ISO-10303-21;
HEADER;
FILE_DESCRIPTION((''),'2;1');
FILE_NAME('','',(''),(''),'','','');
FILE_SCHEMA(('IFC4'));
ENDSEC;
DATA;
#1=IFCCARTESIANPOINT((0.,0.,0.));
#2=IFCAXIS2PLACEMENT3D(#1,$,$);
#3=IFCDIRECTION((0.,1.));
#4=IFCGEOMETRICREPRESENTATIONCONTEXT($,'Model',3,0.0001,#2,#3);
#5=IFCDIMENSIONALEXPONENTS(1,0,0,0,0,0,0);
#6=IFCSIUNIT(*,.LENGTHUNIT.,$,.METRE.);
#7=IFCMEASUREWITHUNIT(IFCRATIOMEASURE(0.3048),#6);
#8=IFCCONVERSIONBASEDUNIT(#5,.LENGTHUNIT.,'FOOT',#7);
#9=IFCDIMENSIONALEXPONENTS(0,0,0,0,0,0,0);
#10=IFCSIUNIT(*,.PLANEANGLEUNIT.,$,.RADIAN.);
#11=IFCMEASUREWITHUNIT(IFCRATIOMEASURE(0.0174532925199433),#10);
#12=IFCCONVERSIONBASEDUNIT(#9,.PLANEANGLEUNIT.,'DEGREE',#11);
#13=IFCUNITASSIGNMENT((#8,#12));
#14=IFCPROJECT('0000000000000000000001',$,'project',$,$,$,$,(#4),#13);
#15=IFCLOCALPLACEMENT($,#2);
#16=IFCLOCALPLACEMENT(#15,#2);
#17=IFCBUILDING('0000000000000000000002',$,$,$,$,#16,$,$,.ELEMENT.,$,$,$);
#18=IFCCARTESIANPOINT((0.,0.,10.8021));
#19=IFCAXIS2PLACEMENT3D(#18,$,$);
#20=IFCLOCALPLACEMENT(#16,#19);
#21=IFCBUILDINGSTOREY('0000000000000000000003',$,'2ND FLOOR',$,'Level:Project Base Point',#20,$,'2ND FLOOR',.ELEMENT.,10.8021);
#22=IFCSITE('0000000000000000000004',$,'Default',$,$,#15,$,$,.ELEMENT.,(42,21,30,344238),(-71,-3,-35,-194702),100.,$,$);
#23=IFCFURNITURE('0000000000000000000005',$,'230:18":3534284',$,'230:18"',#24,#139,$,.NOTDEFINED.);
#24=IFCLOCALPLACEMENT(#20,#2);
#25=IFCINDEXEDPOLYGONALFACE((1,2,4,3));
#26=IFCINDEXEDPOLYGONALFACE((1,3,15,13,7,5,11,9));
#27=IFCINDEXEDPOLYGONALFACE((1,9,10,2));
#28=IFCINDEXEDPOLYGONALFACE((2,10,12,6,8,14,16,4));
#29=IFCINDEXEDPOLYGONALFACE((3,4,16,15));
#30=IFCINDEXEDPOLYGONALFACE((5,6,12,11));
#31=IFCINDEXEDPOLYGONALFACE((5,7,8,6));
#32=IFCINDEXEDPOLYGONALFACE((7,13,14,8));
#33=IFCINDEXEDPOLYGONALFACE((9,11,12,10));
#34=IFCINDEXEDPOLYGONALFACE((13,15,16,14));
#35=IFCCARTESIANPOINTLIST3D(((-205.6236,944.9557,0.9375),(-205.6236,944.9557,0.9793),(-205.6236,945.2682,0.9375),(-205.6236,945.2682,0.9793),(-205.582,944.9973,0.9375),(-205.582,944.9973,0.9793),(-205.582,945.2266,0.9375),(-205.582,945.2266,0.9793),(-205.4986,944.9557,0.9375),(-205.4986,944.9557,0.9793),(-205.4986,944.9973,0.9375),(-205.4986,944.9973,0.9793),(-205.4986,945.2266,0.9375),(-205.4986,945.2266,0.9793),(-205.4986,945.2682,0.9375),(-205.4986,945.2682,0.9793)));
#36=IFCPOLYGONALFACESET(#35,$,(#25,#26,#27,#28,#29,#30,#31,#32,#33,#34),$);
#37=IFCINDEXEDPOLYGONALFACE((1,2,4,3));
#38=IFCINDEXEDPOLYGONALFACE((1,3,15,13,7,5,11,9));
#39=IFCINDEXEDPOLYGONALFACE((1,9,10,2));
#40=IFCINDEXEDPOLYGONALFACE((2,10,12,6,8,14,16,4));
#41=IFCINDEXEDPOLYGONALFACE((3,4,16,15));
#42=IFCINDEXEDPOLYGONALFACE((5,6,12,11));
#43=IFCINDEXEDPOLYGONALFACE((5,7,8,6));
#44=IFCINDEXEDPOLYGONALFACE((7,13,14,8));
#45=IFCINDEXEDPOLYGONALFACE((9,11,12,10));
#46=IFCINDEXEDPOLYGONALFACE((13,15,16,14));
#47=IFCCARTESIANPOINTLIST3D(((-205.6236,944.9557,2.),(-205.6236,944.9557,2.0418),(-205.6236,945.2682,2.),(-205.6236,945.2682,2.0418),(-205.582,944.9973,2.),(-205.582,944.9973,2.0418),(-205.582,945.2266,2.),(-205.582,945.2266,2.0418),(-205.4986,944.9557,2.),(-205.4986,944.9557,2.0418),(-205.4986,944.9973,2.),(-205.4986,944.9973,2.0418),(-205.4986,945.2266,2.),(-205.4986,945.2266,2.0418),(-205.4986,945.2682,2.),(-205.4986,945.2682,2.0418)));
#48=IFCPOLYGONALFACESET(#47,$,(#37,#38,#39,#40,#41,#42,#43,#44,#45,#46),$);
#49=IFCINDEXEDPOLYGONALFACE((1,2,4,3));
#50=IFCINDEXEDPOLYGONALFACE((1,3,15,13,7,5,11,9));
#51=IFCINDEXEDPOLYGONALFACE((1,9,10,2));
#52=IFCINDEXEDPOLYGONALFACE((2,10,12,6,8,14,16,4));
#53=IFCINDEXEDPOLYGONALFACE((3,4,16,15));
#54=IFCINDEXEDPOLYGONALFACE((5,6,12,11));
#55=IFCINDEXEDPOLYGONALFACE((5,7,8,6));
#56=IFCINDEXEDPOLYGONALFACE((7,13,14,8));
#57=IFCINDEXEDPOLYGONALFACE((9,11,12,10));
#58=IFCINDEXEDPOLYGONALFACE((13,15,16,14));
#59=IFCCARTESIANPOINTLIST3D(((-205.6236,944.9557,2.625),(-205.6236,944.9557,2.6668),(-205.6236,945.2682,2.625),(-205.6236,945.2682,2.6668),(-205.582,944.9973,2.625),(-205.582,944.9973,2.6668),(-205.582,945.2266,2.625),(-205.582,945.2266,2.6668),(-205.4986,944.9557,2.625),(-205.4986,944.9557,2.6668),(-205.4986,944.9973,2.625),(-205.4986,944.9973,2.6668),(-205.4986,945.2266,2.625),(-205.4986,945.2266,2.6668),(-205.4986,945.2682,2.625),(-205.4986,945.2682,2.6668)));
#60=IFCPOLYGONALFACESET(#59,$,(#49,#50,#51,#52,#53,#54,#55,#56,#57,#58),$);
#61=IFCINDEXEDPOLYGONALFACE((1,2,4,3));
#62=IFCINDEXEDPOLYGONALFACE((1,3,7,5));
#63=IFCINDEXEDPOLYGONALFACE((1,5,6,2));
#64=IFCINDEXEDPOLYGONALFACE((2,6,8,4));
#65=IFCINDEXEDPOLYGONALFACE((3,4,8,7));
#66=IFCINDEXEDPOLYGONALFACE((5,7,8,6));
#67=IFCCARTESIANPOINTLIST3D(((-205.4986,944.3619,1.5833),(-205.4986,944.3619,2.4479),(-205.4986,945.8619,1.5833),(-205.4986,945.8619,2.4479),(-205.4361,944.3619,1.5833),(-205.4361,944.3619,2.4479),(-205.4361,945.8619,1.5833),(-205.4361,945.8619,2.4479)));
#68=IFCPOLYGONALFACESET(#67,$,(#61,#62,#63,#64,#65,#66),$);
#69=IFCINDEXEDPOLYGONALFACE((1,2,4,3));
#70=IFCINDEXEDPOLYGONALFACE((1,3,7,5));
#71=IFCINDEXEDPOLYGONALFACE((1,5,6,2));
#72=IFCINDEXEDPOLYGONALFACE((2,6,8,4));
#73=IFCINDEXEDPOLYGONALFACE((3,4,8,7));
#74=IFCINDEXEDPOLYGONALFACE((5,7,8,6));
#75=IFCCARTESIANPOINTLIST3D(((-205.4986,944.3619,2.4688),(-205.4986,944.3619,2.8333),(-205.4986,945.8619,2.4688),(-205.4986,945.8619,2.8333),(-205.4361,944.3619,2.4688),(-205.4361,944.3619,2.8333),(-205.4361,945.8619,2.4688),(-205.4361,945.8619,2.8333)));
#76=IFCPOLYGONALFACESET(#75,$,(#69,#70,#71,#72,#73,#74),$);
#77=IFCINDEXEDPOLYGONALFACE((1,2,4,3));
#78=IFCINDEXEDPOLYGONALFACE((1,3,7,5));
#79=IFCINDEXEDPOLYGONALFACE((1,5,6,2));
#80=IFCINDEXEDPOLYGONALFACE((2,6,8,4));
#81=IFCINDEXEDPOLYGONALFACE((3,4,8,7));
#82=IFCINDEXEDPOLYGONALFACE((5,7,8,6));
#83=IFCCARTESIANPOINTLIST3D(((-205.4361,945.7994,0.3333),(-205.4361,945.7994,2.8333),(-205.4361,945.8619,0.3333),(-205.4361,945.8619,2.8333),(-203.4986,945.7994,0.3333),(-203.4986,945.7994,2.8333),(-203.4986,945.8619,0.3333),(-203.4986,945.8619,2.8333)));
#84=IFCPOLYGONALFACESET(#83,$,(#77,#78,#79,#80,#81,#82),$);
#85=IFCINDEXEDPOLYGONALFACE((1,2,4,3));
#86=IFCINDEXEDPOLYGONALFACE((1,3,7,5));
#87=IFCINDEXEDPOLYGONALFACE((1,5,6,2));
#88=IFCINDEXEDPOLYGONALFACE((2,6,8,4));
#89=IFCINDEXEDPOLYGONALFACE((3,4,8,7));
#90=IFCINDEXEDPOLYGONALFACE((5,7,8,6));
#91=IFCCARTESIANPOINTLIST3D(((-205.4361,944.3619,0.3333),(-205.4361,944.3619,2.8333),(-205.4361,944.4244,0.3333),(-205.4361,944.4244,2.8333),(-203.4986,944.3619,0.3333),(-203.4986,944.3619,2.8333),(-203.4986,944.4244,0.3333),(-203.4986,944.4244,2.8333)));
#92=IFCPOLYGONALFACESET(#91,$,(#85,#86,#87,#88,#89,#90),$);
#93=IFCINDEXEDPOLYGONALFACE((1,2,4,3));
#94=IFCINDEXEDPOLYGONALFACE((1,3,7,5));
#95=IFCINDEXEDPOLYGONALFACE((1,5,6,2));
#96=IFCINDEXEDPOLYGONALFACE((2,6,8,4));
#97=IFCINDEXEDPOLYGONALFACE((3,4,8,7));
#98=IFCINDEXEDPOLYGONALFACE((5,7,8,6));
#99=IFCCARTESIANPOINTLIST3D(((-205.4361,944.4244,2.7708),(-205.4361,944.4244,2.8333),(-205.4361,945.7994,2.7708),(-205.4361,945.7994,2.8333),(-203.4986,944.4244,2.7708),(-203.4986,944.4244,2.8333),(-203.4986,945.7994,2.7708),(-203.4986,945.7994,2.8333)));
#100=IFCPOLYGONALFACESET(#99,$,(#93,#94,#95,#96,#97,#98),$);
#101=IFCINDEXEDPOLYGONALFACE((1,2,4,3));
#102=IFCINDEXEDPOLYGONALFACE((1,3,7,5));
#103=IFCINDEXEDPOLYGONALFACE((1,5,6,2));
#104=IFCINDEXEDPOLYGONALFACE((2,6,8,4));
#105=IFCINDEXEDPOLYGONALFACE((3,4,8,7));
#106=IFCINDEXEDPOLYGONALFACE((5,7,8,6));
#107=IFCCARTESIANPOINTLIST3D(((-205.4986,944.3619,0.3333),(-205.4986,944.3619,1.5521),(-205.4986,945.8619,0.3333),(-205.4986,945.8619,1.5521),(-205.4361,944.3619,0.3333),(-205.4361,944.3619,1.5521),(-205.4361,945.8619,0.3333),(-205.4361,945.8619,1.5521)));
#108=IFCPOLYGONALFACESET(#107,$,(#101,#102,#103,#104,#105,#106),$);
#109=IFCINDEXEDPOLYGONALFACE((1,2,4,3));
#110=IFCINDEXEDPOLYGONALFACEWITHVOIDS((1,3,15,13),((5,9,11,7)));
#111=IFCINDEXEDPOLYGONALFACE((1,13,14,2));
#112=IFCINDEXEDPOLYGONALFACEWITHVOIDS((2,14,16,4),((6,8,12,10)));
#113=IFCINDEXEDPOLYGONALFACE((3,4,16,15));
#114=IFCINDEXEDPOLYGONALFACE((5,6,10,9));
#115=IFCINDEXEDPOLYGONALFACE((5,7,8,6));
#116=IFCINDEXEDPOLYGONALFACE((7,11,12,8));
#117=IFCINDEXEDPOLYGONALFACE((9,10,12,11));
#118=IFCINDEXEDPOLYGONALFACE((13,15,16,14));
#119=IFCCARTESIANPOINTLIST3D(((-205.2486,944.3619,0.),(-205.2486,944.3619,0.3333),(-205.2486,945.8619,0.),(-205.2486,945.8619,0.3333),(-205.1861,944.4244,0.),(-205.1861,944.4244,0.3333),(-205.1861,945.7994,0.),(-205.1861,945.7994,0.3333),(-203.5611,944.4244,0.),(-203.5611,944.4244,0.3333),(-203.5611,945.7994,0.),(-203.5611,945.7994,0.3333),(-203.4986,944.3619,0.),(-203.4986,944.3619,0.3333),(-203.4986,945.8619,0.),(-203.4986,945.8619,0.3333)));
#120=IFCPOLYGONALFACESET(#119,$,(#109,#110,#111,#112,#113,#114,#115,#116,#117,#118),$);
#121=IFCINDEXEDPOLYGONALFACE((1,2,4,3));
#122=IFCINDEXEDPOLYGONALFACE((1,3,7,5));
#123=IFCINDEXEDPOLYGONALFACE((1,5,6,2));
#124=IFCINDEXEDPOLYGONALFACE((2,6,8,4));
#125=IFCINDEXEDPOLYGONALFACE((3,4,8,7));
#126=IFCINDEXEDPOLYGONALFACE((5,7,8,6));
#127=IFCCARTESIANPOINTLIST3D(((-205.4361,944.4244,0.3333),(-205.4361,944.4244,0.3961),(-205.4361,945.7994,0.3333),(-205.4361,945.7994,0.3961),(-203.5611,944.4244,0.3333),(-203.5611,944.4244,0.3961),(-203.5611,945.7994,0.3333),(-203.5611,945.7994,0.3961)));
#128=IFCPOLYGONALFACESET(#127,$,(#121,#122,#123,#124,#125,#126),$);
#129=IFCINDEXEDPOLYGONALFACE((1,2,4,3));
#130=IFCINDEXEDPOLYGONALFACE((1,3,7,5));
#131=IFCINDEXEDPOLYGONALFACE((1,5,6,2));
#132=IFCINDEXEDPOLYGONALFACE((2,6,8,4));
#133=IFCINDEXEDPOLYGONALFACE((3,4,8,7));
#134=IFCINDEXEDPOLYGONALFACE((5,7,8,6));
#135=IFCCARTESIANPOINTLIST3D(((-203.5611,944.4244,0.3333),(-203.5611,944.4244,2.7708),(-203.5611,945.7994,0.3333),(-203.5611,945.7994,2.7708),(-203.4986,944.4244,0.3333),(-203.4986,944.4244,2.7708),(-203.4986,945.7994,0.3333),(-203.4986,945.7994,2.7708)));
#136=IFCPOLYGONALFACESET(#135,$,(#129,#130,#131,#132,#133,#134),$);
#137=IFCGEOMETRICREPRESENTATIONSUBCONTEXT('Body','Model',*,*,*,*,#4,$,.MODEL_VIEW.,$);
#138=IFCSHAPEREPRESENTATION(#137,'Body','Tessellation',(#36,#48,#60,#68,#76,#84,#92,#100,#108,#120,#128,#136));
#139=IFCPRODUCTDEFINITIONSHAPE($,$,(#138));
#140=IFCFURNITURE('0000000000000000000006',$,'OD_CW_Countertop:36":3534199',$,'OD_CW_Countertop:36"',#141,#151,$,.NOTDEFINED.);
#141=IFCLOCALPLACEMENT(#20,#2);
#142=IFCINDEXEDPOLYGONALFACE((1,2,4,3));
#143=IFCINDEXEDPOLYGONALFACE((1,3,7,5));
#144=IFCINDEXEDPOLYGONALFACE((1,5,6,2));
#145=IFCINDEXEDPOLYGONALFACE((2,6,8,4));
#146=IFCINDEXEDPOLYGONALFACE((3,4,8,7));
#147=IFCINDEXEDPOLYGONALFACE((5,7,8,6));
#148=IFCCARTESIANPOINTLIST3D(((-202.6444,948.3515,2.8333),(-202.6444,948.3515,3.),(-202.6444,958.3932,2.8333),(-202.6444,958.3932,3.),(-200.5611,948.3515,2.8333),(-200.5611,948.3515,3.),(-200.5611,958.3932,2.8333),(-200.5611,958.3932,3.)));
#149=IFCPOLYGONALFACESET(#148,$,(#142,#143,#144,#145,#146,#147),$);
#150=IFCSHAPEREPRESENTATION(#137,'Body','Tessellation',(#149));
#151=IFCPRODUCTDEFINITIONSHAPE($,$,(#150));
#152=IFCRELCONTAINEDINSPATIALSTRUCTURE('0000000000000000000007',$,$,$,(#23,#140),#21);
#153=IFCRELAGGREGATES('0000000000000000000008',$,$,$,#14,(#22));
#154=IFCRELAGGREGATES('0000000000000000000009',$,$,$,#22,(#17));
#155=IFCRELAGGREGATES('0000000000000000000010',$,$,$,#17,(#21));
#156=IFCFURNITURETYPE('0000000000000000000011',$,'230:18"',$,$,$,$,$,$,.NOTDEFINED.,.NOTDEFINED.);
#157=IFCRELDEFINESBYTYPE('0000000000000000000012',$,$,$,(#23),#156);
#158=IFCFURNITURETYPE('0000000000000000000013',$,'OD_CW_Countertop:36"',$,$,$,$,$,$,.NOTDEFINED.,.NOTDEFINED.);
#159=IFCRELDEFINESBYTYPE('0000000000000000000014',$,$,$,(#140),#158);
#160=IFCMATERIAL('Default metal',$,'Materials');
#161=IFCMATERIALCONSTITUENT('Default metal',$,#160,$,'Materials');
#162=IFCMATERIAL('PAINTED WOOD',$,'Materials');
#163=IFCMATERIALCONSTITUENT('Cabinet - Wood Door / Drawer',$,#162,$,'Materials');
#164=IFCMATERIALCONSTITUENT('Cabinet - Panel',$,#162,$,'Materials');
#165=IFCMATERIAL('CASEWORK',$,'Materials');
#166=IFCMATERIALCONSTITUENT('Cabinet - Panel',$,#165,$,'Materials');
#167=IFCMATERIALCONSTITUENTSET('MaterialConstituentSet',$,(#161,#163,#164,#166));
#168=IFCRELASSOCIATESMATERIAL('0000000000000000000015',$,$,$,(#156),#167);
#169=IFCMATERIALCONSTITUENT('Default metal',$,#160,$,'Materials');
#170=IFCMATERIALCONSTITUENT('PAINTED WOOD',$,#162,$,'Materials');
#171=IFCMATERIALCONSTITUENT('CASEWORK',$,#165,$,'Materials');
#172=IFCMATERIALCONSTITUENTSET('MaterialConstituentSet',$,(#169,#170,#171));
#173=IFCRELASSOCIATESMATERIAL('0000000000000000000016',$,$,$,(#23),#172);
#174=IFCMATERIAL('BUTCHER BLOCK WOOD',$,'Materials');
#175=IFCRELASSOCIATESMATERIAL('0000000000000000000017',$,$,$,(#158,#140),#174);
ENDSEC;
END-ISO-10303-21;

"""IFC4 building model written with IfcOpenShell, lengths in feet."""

from ifc_helpers import new_model, entity, si_unit, converted_unit, direction, frame, frame_2d, origin, origin_2d_with_axis, place, context, subcontext, project, spatial, polyline, rectangle, outline, extrude, source, transform, mapped, material, constituent, constituent_set, type_object, type_shapes, element, save


model = new_model("IFC4")

# Units and contexts
model_context = context("Model", 3, precision=0.0001, world=origin(), true_north=direction((0.0, 1.0)))
body_context = subcontext(model_context, "Body", "Model", "MODEL_VIEW")
ifc_project = project(units=[converted_unit("LENGTHUNIT", "FOOT", entity("IfcRatioMeasure", 0.3048), si_unit("LENGTHUNIT", "METRE"), dimensions=[1, 0, 0, 0, 0, 0, 0]), converted_unit("PLANEANGLEUNIT", "DEGREE", entity("IfcRatioMeasure", 0.0174532925199433), si_unit("PLANEANGLEUNIT", "RADIAN"), dimensions=[0, 0, 0, 0, 0, 0, 0])], contexts=[model_context])

# Site, building, storey
site_placement = place(None, origin())
site = spatial("IfcSite", under=ifc_project, at=site_placement, Name="Default", CompositionType="ELEMENT", RefLatitude=(42, 21, 30, 344238), RefLongitude=(-71, -3, -35, -194702), RefElevation=100.0)
building_placement = place(site_placement, origin())
building = spatial("IfcBuilding", under=site, at=building_placement, CompositionType="ELEMENT")
storey_placement = place(building_placement, frame((0.0, 0.0, 10.8021)))
storey = spatial("IfcBuildingStorey", under=building, at=storey_placement, Name="2ND FLOOR", ObjectType="Level:Project Base Point", LongName="2ND FLOOR", CompositionType="ELEMENT", Elevation=10.8021)

# Furniture
ifc_material_1 = material(Name="CASEWORK", Category="Materials")
ifc_material_2 = material(Name="PAINTED WOOD", Category="Materials")
ifc_material_3 = material(Name="Default metal", Category="Materials")
ifc_material_4 = material(Name="BUTCHER BLOCK WOOD", Category="Materials")
ifc_constituent_1 = constituent(ifc_material_3, Name="Default metal", Category="Materials")
ifc_constituent_2 = constituent(ifc_material_2, Name="Cabinet - Wood Door / Drawer", Category="Materials")
ifc_constituent_3 = constituent(ifc_material_2, Name="Cabinet - Panel", Category="Materials")
ifc_constituent_4 = constituent(ifc_material_1, Name="Cabinet - Panel", Category="Materials")
ifc_constituent_set_1 = constituent_set(constituents=[ifc_constituent_1, ifc_constituent_2, ifc_constituent_3, ifc_constituent_4], Name="MaterialConstituentSet")
furniture_type_1 = type_object("IfcFurnitureType", Name="230:18\"", AssemblyPlace="NOTDEFINED", PredefinedType="NOTDEFINED", material=ifc_constituent_set_1)
shared_shape_1 = source(origin(), body_context, "Body", "SweptSolid", [
    extrude(outline(polyline([(-0.0521, -0.1562), (0.0729, -0.1562), (0.0729, 0.1562), (-0.0521, 0.1562), (-0.0521, 0.1146), (0.0313, 0.1146), (0.0313, -0.1146), (-0.0521, -0.1146), (-0.0521, -0.1562)])), frame((0.0615, -2.0521, 0.9375), z_axis=(0.0, 0.0, 1.0), x_axis=(0.0, -1.0, 0.0)), (0.0, 0.0, 1.0), 0.0418),
    extrude(outline(polyline([(-0.0521, -0.1562), (0.0729, -0.1562), (0.0729, 0.1562), (-0.0521, 0.1562), (-0.0521, 0.1146), (0.0313, 0.1146), (0.0313, -0.1146), (-0.0521, -0.1146), (-0.0521, -0.1562)])), frame((0.0615, -2.0521, 2.0), z_axis=(0.0, 0.0, 1.0), x_axis=(0.0, -1.0, 0.0)), (0.0, 0.0, 1.0), 0.0418),
    extrude(outline(polyline([(-0.0521, -0.1562), (0.0729, -0.1562), (0.0729, 0.1562), (-0.0521, 0.1562), (-0.0521, 0.1146), (0.0313, 0.1146), (0.0313, -0.1146), (-0.0521, -0.1146), (-0.0521, -0.1562)])), frame((0.0615, -2.0521, 2.625), z_axis=(0.0, 0.0, 1.0), x_axis=(0.0, -1.0, 0.0)), (0.0, 0.0, 1.0), 0.0418),
    extrude(rectangle(XDim=0.0625, YDim=1.5, at=frame_2d((0.0, 0.0), x_axis=(1.0, 0.0))), frame((0.0615, -1.9688, 1.5833), z_axis=(0.0, 0.0, 1.0), x_axis=(0.0, 1.0, 0.0)), (0.0, 0.0, 1.0), 0.8646),
    extrude(rectangle(XDim=0.0625, YDim=1.5, at=frame_2d((0.0, 0.0), x_axis=(1.0, 0.0))), frame((0.0615, -1.9688, 2.4688), z_axis=(0.0, 0.0, 1.0), x_axis=(0.0, 1.0, 0.0)), (0.0, 0.0, 1.0), 0.3646),
    extrude(rectangle(XDim=0.0625, YDim=1.9375, at=frame_2d((0.0, 0.0), x_axis=(1.0, 0.0))), frame((-0.6573, -0.9687, 0.3333)), (0.0, 0.0, 1.0), 2.5),
    extrude(rectangle(XDim=0.0625, YDim=1.9375, at=frame_2d((0.0, 0.0), x_axis=(1.0, 0.0))), frame((0.7802, -0.9687, 0.3333)), (0.0, 0.0, 1.0), 2.5),
    extrude(rectangle(XDim=1.375, YDim=1.9375, at=origin_2d_with_axis()), frame((0.0615, -0.9687, 2.7708), z_axis=(0.0, 0.0, 1.0), x_axis=(-1.0, 0.0, 0.0)), (0.0, 0.0, 1.0), 0.0625),
    extrude(rectangle(XDim=0.0625, YDim=1.5, at=frame_2d((0.0, 0.0), x_axis=(1.0, 0.0))), frame((0.0615, -1.9688, 0.3333), z_axis=(0.0, 0.0, 1.0), x_axis=(0.0, 1.0, 0.0)), (0.0, 0.0, 1.0), 1.2187),
    extrude(outline(polyline([(-0.75, -0.875), (0.75, -0.875), (0.75, 0.875), (-0.75, 0.875), (-0.75, -0.875)]), holes=[polyline([(-0.6875, -0.8125), (-0.6875, 0.8125), (0.6875, 0.8125), (0.6875, -0.8125), (-0.6875, -0.8125)])]), frame((0.0615, -0.875, 0.0)), (0.0, 0.0, 1.0), 0.3333),
    extrude(rectangle(XDim=1.375, YDim=1.875, at=frame_2d((0.0, 0.0), x_axis=(1.0, 0.0))), frame((0.0615, -1.0, 0.3333), z_axis=(0.0, 0.0, 1.0), x_axis=(-1.0, 0.0, 0.0)), (0.0, 0.0, 1.0), 0.0627),
    extrude(rectangle(XDim=0.0625, YDim=1.375, at=origin_2d_with_axis()), frame((0.0615, -0.0312, 0.3333), z_axis=(0.0, 0.0, 1.0), x_axis=(0.0, 1.0, 0.0)), (0.0, 0.0, 1.0), 2.4375),
])
type_shapes(furniture_type_1, [shared_shape_1])
ifc_constituent_5 = constituent(ifc_material_3, Name="Default metal", Category="Materials")
ifc_constituent_6 = constituent(ifc_material_2, Name="PAINTED WOOD", Category="Materials")
ifc_constituent_7 = constituent(ifc_material_1, Name="CASEWORK", Category="Materials")
ifc_constituent_set_2 = constituent_set(constituents=[ifc_constituent_5, ifc_constituent_6, ifc_constituent_7], Name="MaterialConstituentSet")
furniture_1_placement = place(storey_placement, frame((-203.4986, 945.1734, 0.0), z_axis=(0.0, 0.0, 1.0), x_axis=(0.0, -1.0, 0.0)))
element("IfcFurniture", 1, at=furniture_1_placement, inside=storey, type_object=furniture_type_1, material=ifc_constituent_set_2, Name="230:18\":3534284", ObjectType="230:18\"", PredefinedType="NOTDEFINED", context=body_context, shape_type="MappedRepresentation", body=[
    mapped(shared_shape_1, transform((0.0, 0.0, 0.0), scale=1.0)),
])
furniture_type_2 = type_object("IfcFurnitureType", Name="OD_CW_Countertop:36\"", AssemblyPlace="NOTDEFINED", PredefinedType="NOTDEFINED", material=ifc_material_4)
shared_shape_2 = source(origin(), body_context, "Body", "SweptSolid", [
    extrude(rectangle(XDim=10.0417, YDim=2.0833, at=origin_2d_with_axis()), frame((5.0208, 1.0417, 0.0)), (0.0, 0.0, 1.0), 0.1667),
])
type_shapes(furniture_type_2, [shared_shape_2])
furniture_2_placement = place(storey_placement, frame((-202.6444, 958.3932, 2.8333), z_axis=(0.0, 0.0, 1.0), x_axis=(0.0, -1.0, 0.0)))
element("IfcFurniture", 2, at=furniture_2_placement, inside=storey, type_object=furniture_type_2, material=ifc_material_4, Name="OD_CW_Countertop:36\":3534199", ObjectType="OD_CW_Countertop:36\"", PredefinedType="NOTDEFINED", context=body_context, shape_type="MappedRepresentation", body=[
    mapped(shared_shape_2, transform((0.0, 0.0, 0.0), scale=1.0)),
])

save(model, "model.ifc")
